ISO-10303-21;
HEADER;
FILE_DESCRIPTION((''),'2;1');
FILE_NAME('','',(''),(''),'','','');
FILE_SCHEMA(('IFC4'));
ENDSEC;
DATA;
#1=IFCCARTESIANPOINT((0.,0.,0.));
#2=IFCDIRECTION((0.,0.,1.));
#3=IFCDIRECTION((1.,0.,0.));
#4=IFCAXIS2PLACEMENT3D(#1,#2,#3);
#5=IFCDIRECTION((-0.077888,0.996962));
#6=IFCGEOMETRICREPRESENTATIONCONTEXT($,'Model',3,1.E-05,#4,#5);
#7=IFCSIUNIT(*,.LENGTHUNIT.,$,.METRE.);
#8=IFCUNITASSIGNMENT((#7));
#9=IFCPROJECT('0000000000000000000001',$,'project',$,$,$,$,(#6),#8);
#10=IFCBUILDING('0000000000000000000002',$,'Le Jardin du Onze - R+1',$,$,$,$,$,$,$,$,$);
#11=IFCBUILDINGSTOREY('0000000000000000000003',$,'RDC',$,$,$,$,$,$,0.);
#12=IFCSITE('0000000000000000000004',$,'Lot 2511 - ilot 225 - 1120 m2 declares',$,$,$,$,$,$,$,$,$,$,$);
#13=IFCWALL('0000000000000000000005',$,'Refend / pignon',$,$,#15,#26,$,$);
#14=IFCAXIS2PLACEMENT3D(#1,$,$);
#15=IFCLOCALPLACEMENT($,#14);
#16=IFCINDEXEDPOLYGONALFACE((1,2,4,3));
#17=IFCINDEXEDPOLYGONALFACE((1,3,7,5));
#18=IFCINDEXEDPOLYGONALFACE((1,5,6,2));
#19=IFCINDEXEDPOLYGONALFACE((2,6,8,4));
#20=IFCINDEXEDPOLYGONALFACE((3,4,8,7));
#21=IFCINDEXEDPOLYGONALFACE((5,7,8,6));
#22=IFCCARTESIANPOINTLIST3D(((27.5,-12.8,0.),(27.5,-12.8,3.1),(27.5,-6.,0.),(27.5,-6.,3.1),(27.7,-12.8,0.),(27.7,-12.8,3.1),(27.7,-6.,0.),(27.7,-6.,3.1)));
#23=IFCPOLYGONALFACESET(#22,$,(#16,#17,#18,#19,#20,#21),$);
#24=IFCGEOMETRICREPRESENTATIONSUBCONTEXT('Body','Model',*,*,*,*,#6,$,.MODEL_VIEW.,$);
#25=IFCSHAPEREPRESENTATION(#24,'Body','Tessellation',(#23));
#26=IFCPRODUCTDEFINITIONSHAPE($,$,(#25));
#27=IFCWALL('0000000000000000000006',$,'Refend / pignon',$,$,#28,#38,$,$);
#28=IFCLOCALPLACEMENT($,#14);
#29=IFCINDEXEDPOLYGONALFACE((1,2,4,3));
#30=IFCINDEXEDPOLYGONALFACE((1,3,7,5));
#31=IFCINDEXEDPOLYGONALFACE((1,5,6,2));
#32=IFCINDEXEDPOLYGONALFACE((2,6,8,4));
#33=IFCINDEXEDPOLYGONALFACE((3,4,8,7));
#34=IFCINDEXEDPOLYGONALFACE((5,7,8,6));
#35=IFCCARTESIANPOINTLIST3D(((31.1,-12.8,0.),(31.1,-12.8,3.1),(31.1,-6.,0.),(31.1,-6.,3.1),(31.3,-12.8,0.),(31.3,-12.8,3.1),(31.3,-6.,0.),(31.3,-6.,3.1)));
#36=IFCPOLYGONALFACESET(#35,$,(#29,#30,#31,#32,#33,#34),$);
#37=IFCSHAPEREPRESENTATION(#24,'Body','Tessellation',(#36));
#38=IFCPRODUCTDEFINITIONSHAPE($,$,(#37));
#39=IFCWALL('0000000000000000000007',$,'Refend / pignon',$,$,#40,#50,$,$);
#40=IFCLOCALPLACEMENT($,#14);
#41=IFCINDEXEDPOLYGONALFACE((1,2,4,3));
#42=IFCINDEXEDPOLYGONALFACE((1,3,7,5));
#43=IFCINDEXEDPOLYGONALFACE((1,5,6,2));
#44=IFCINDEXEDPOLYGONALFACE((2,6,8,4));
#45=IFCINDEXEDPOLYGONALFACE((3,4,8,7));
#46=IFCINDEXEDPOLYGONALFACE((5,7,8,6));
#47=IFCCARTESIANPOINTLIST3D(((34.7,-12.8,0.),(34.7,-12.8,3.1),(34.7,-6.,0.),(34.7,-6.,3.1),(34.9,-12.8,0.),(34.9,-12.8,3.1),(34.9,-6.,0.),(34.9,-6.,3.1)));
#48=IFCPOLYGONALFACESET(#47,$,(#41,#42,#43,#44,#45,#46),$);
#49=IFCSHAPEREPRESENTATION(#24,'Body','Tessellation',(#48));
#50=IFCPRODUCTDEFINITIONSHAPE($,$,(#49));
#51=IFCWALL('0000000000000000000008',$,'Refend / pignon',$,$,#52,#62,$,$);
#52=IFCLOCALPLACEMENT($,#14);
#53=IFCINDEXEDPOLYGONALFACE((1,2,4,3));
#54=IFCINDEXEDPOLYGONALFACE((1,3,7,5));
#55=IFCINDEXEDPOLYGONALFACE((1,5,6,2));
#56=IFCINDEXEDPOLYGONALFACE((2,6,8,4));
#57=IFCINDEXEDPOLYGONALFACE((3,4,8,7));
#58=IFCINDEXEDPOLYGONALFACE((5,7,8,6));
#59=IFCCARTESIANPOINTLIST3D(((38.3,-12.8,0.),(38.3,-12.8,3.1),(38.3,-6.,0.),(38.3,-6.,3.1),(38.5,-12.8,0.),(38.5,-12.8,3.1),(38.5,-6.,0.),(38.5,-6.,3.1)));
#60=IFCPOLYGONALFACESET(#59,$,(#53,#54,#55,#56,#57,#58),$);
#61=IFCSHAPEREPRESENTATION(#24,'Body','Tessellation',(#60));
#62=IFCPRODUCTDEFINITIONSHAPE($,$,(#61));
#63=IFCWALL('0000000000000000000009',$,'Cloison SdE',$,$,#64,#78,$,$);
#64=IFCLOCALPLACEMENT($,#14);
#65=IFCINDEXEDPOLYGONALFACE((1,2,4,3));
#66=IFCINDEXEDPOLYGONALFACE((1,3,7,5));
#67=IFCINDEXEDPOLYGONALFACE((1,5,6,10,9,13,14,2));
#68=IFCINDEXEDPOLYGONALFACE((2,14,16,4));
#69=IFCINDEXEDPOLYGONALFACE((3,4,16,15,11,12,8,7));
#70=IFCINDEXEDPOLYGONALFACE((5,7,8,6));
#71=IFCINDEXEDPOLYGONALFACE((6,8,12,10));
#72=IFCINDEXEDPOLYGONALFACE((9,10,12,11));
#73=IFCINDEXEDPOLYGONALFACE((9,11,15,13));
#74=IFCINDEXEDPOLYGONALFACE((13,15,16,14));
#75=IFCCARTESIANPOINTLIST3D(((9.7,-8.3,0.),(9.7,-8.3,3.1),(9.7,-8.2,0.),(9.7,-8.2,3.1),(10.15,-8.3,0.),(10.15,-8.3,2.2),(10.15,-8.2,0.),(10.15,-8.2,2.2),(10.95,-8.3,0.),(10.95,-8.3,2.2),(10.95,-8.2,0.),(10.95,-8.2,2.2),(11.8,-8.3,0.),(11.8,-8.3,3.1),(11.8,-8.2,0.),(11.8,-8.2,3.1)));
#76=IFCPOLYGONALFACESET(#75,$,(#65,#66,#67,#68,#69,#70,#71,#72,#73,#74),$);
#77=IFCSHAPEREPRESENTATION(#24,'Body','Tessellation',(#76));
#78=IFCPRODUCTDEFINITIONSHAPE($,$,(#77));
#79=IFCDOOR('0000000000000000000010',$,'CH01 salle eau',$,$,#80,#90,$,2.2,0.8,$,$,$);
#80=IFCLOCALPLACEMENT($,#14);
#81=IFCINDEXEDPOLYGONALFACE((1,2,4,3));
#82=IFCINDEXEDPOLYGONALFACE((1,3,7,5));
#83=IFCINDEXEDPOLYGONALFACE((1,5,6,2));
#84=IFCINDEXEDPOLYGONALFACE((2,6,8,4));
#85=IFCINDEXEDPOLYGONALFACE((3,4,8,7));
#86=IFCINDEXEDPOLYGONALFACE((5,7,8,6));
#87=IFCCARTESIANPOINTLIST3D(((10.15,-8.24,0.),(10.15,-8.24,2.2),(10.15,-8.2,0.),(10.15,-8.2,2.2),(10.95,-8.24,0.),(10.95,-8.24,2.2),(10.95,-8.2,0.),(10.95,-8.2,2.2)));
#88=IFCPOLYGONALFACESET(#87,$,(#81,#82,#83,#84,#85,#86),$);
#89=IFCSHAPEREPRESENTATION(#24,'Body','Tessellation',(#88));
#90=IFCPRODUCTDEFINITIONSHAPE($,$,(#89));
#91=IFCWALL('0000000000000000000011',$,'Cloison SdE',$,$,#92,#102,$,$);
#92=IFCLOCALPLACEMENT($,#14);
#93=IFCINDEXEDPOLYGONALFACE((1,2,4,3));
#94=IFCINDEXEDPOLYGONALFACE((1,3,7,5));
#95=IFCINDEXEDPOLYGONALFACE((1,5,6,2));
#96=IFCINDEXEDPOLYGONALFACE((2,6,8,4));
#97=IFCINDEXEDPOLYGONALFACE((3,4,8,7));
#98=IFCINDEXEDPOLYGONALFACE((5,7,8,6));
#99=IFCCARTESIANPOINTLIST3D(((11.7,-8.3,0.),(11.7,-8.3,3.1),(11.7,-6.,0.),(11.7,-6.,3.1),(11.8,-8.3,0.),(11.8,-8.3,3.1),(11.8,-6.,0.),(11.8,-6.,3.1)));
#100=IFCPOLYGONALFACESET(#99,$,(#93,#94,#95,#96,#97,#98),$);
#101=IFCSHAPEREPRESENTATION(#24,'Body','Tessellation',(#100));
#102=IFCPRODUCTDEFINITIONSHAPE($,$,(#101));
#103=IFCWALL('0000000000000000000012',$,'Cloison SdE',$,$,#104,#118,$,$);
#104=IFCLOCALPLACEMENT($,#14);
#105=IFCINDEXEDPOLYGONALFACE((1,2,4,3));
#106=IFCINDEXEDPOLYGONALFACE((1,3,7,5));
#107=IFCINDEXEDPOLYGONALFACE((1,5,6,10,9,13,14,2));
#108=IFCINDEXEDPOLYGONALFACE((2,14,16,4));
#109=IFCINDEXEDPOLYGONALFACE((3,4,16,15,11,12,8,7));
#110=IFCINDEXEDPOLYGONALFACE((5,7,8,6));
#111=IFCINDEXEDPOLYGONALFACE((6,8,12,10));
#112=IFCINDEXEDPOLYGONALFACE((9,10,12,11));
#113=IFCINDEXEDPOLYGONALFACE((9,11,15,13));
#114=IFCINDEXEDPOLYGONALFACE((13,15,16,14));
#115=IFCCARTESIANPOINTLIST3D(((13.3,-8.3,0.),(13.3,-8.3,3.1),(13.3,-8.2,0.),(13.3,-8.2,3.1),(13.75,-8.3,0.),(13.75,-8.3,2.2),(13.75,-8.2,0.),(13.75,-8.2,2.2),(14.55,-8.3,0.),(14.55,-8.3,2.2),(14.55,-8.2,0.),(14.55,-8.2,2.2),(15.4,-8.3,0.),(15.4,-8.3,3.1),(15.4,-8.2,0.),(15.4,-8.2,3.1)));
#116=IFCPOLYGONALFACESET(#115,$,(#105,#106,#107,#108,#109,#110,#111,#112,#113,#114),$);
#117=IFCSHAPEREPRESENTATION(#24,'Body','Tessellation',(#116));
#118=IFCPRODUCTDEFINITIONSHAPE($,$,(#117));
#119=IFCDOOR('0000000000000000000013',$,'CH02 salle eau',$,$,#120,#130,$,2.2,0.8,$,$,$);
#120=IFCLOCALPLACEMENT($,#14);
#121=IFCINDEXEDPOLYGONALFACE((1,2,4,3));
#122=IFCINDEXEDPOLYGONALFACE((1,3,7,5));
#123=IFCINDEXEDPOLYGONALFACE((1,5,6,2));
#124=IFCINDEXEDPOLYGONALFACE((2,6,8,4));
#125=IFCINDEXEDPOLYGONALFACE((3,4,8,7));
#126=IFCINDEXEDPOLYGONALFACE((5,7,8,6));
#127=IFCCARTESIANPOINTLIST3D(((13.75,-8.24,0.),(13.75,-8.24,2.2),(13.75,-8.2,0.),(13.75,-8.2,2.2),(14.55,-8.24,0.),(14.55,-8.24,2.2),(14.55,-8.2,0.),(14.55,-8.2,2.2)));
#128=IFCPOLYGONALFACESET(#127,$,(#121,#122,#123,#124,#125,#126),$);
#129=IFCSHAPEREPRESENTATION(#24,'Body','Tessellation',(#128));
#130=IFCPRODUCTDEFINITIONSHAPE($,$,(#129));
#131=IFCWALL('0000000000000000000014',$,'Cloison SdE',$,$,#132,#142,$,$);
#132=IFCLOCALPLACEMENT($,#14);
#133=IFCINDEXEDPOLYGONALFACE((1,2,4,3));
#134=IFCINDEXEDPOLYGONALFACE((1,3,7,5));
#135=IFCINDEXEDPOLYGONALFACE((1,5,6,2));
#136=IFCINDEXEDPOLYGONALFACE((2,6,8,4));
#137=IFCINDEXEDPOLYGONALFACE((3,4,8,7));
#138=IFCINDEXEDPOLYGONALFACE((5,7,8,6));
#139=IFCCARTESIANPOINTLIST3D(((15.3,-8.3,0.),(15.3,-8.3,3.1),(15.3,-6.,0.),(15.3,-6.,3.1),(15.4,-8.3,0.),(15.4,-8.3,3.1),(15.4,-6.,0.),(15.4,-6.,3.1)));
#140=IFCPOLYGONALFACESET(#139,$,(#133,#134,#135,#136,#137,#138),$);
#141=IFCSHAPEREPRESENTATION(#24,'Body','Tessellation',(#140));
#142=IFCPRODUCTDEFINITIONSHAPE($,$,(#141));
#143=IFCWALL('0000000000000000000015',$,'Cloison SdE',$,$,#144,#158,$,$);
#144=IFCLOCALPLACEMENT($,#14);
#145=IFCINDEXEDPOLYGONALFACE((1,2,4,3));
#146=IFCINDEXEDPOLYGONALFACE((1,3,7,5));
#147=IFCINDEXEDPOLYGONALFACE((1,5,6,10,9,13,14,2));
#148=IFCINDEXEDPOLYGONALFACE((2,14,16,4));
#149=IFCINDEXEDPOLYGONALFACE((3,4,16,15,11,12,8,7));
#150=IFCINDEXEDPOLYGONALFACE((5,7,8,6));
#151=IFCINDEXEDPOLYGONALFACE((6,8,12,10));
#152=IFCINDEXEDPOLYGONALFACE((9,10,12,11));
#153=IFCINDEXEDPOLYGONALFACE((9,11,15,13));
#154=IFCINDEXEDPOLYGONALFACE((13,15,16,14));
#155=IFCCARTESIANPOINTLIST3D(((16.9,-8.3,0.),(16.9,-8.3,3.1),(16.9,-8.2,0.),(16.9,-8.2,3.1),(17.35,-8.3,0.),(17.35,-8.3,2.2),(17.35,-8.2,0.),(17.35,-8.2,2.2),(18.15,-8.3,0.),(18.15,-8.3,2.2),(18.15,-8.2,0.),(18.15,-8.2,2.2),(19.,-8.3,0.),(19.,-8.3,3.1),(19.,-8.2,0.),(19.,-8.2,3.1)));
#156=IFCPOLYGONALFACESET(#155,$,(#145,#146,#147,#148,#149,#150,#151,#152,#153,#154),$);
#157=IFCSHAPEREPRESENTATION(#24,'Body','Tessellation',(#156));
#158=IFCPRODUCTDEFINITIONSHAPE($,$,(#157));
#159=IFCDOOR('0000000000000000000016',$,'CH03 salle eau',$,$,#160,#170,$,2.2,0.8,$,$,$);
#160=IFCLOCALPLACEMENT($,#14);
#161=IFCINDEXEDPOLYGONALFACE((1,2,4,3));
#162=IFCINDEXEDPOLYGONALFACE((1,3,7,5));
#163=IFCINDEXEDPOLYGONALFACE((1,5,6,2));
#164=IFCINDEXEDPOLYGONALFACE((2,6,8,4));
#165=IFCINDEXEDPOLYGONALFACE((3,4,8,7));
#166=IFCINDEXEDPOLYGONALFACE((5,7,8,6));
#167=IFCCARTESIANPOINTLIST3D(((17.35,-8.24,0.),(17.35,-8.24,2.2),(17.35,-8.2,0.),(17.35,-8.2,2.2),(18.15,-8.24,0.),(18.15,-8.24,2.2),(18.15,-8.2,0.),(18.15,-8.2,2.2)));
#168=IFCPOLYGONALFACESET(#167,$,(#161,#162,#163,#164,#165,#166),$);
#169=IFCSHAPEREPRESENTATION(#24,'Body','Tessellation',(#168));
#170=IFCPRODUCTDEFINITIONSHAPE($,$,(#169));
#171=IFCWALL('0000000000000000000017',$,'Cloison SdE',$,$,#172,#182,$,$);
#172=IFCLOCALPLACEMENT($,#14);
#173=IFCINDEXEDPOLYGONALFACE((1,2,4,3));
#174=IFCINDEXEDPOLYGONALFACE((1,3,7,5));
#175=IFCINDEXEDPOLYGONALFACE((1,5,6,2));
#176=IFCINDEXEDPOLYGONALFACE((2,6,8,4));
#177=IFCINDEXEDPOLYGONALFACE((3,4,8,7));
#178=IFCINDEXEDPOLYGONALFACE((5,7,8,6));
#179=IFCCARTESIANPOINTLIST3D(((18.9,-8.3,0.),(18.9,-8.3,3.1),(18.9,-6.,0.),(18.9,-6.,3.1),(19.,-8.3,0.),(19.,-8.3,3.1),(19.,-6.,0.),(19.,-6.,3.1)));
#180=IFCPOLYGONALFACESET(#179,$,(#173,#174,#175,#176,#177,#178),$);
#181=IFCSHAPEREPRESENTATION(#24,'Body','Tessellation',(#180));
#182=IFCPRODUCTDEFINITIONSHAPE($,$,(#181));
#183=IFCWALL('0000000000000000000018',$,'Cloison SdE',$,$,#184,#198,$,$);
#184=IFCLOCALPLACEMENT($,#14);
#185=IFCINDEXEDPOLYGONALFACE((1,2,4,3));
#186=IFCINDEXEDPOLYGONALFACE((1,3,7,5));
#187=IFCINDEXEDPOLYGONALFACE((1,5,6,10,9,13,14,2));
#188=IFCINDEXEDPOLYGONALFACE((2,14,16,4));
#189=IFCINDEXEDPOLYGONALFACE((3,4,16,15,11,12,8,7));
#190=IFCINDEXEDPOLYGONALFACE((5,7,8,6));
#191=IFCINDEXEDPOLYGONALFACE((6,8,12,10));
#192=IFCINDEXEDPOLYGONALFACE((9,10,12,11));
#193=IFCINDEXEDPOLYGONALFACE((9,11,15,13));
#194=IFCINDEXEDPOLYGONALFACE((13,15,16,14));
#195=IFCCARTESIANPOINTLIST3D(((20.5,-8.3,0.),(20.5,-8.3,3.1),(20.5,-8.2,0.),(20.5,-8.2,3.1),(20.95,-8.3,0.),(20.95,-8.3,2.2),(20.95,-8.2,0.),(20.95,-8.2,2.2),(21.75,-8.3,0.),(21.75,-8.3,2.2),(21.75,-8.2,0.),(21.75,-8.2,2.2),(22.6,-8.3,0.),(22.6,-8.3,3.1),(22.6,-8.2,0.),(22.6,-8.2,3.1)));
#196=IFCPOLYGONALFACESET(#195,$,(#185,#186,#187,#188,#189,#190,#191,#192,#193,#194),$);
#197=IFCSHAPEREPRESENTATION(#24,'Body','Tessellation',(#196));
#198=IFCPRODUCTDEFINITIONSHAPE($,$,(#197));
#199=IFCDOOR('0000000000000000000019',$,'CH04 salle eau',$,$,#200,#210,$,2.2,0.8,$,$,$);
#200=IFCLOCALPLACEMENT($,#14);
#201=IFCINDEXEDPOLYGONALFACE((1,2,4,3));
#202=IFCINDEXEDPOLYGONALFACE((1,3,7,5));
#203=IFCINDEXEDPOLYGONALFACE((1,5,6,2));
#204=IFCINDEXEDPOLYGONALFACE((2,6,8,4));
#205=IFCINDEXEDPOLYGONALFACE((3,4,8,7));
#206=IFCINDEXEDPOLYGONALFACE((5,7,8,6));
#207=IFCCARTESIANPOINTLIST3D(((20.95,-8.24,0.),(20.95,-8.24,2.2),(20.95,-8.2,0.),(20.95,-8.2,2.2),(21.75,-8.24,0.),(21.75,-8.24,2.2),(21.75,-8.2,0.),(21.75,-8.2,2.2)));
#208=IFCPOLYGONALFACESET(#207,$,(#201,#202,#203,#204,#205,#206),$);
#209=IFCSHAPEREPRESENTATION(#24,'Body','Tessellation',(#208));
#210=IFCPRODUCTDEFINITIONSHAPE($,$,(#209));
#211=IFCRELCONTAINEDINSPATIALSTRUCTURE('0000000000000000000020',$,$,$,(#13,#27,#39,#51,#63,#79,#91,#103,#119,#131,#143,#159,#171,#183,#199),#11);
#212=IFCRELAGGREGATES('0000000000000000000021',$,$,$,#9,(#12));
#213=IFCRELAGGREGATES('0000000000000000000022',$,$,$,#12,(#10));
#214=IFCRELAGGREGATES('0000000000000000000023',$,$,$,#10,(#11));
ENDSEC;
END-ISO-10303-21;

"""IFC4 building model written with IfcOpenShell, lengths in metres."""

from ifc_helpers import new_model, si_unit, direction, origin, origin_with_axes, place, context, subcontext, project, spatial, polyline, outline, extrude, element, fill, save


model = new_model("IFC4")

# Units and contexts
model_context = context("Model", 3, precision=1e-05, world=origin_with_axes(), true_north=direction((-0.077888, 0.996962)))
body_context = subcontext(model_context, "Body", "Model", "MODEL_VIEW")
ifc_project = project(units=[si_unit("LENGTHUNIT", "METRE")], contexts=[model_context])

# Site, building, storey
site = spatial("IfcSite", under=ifc_project, Name="Lot 2511 - ilot 225 - 1120 m2 declares")
building = spatial("IfcBuilding", under=site, Name="Le Jardin du Onze - R+1")
storey = spatial("IfcBuildingStorey", under=building, Name="RDC", Elevation=0.0)

# Walls
wall_1_placement = place(None, origin_with_axes())
element("IfcWall", 1, at=wall_1_placement, inside=storey, Name="Refend / pignon", context=body_context, shape_type="SweptSolid", body=[
    extrude(outline(polyline([(27.7, -12.8), (27.7, -6.0), (27.5, -6.0), (27.5, -12.8), (27.7, -12.8)])), origin(), (0.0, 0.0, 1.0), 3.1),
])
wall_2_placement = place(None, origin_with_axes())
element("IfcWall", 2, at=wall_2_placement, inside=storey, Name="Refend / pignon", context=body_context, shape_type="SweptSolid", body=[
    extrude(outline(polyline([(31.3, -12.8), (31.3, -6.0), (31.1, -6.0), (31.1, -12.8), (31.3, -12.8)])), origin(), (0.0, 0.0, 1.0), 3.1),
])
wall_3_placement = place(None, origin_with_axes())
element("IfcWall", 3, at=wall_3_placement, inside=storey, Name="Refend / pignon", context=body_context, shape_type="SweptSolid", body=[
    extrude(outline(polyline([(34.9, -12.8), (34.9, -6.0), (34.7, -6.0), (34.7, -12.8), (34.9, -12.8)])), origin(), (0.0, 0.0, 1.0), 3.1),
])
wall_4_placement = place(None, origin_with_axes())
element("IfcWall", 4, at=wall_4_placement, inside=storey, Name="Refend / pignon", context=body_context, shape_type="SweptSolid", body=[
    extrude(outline(polyline([(38.5, -12.8), (38.5, -6.0), (38.3, -6.0), (38.3, -12.8), (38.5, -12.8)])), origin(), (0.0, 0.0, 1.0), 3.1),
])

# Wall, opening, door
wall_5_placement = place(None, origin_with_axes())
wall_5 = element("IfcWall", 5, at=wall_5_placement, inside=storey, Name="Cloison SdE", context=body_context, shape_type="SweptSolid", body=[
    extrude(outline(polyline([(11.8, -8.3), (11.8, -8.2), (9.7, -8.2), (9.7, -8.3), (11.8, -8.3)])), origin(), (0.0, 0.0, 1.0), 3.1),
])
opening_1_placement = place(None, origin_with_axes())
opening_1 = element("IfcOpeningElement", 6, at=opening_1_placement, cuts=wall_5, context=body_context, shape_type="SweptSolid", body=[
    extrude(outline(polyline([(10.95, -8.34), (10.95, -8.06), (10.15, -8.06), (10.15, -8.34), (10.95, -8.34)])), origin(), (0.0, 0.0, 1.0), 2.2),
])
door_1_placement = place(None, origin_with_axes())
door_1 = element("IfcDoor", 7, at=door_1_placement, inside=storey, Name="CH01 salle eau", OverallHeight=2.2, OverallWidth=0.8, context=body_context, shape_type="SweptSolid", body=[
    extrude(outline(polyline([(10.95, -8.24), (10.95, -8.2), (10.15, -8.2), (10.15, -8.24), (10.95, -8.24)])), origin(), (0.0, 0.0, 1.0), 2.2),
])
fill(opening_1, door_1)

# Wall
wall_6_placement = place(None, origin_with_axes())
element("IfcWall", 8, at=wall_6_placement, inside=storey, Name="Cloison SdE", context=body_context, shape_type="SweptSolid", body=[
    extrude(outline(polyline([(11.8, -8.3), (11.8, -6.0), (11.7, -6.0), (11.7, -8.3), (11.8, -8.3)])), origin(), (0.0, 0.0, 1.0), 3.1),
])

# Wall, opening, door
wall_7_placement = place(None, origin_with_axes())
wall_7 = element("IfcWall", 9, at=wall_7_placement, inside=storey, Name="Cloison SdE", context=body_context, shape_type="SweptSolid", body=[
    extrude(outline(polyline([(15.4, -8.3), (15.4, -8.2), (13.3, -8.2), (13.3, -8.3), (15.4, -8.3)])), origin(), (0.0, 0.0, 1.0), 3.1),
])
opening_2_placement = place(None, origin_with_axes())
opening_2 = element("IfcOpeningElement", 10, at=opening_2_placement, cuts=wall_7, context=body_context, shape_type="SweptSolid", body=[
    extrude(outline(polyline([(14.55, -8.34), (14.55, -8.06), (13.75, -8.06), (13.75, -8.34), (14.55, -8.34)])), origin(), (0.0, 0.0, 1.0), 2.2),
])
door_2_placement = place(None, origin_with_axes())
door_2 = element("IfcDoor", 11, at=door_2_placement, inside=storey, Name="CH02 salle eau", OverallHeight=2.2, OverallWidth=0.8, context=body_context, shape_type="SweptSolid", body=[
    extrude(outline(polyline([(14.55, -8.24), (14.55, -8.2), (13.75, -8.2), (13.75, -8.24), (14.55, -8.24)])), origin(), (0.0, 0.0, 1.0), 2.2),
])
fill(opening_2, door_2)

# Wall
wall_8_placement = place(None, origin_with_axes())
element("IfcWall", 12, at=wall_8_placement, inside=storey, Name="Cloison SdE", context=body_context, shape_type="SweptSolid", body=[
    extrude(outline(polyline([(15.4, -8.3), (15.4, -6.0), (15.3, -6.0), (15.3, -8.3), (15.4, -8.3)])), origin(), (0.0, 0.0, 1.0), 3.1),
])

# Wall, opening, door
wall_9_placement = place(None, origin_with_axes())
wall_9 = element("IfcWall", 13, at=wall_9_placement, inside=storey, Name="Cloison SdE", context=body_context, shape_type="SweptSolid", body=[
    extrude(outline(polyline([(19.0, -8.3), (19.0, -8.2), (16.9, -8.2), (16.9, -8.3), (19.0, -8.3)])), origin(), (0.0, 0.0, 1.0), 3.1),
])
opening_3_placement = place(None, origin_with_axes())
opening_3 = element("IfcOpeningElement", 14, at=opening_3_placement, cuts=wall_9, context=body_context, shape_type="SweptSolid", body=[
    extrude(outline(polyline([(18.15, -8.34), (18.15, -8.06), (17.35, -8.06), (17.35, -8.34), (18.15, -8.34)])), origin(), (0.0, 0.0, 1.0), 2.2),
])
door_3_placement = place(None, origin_with_axes())
door_3 = element("IfcDoor", 15, at=door_3_placement, inside=storey, Name="CH03 salle eau", OverallHeight=2.2, OverallWidth=0.8, context=body_context, shape_type="SweptSolid", body=[
    extrude(outline(polyline([(18.15, -8.24), (18.15, -8.2), (17.35, -8.2), (17.35, -8.24), (18.15, -8.24)])), origin(), (0.0, 0.0, 1.0), 2.2),
])
fill(opening_3, door_3)

# Wall
wall_10_placement = place(None, origin_with_axes())
element("IfcWall", 16, at=wall_10_placement, inside=storey, Name="Cloison SdE", context=body_context, shape_type="SweptSolid", body=[
    extrude(outline(polyline([(19.0, -8.3), (19.0, -6.0), (18.9, -6.0), (18.9, -8.3), (19.0, -8.3)])), origin(), (0.0, 0.0, 1.0), 3.1),
])

# Wall, opening, door
wall_11_placement = place(None, origin_with_axes())
wall_11 = element("IfcWall", 17, at=wall_11_placement, inside=storey, Name="Cloison SdE", context=body_context, shape_type="SweptSolid", body=[
    extrude(outline(polyline([(22.6, -8.3), (22.6, -8.2), (20.5, -8.2), (20.5, -8.3), (22.6, -8.3)])), origin(), (0.0, 0.0, 1.0), 3.1),
])
opening_4_placement = place(None, origin_with_axes())
opening_4 = element("IfcOpeningElement", 18, at=opening_4_placement, cuts=wall_11, context=body_context, shape_type="SweptSolid", body=[
    extrude(outline(polyline([(21.75, -8.34), (21.75, -8.06), (20.95, -8.06), (20.95, -8.34), (21.75, -8.34)])), origin(), (0.0, 0.0, 1.0), 2.2),
])
door_4_placement = place(None, origin_with_axes())
door_4 = element("IfcDoor", 19, at=door_4_placement, inside=storey, Name="CH04 salle eau", OverallHeight=2.2, OverallWidth=0.8, context=body_context, shape_type="SweptSolid", body=[
    extrude(outline(polyline([(21.75, -8.24), (21.75, -8.2), (20.95, -8.2), (20.95, -8.24), (21.75, -8.24)])), origin(), (0.0, 0.0, 1.0), 2.2),
])
fill(opening_4, door_4)

save(model, "model.ifc")
